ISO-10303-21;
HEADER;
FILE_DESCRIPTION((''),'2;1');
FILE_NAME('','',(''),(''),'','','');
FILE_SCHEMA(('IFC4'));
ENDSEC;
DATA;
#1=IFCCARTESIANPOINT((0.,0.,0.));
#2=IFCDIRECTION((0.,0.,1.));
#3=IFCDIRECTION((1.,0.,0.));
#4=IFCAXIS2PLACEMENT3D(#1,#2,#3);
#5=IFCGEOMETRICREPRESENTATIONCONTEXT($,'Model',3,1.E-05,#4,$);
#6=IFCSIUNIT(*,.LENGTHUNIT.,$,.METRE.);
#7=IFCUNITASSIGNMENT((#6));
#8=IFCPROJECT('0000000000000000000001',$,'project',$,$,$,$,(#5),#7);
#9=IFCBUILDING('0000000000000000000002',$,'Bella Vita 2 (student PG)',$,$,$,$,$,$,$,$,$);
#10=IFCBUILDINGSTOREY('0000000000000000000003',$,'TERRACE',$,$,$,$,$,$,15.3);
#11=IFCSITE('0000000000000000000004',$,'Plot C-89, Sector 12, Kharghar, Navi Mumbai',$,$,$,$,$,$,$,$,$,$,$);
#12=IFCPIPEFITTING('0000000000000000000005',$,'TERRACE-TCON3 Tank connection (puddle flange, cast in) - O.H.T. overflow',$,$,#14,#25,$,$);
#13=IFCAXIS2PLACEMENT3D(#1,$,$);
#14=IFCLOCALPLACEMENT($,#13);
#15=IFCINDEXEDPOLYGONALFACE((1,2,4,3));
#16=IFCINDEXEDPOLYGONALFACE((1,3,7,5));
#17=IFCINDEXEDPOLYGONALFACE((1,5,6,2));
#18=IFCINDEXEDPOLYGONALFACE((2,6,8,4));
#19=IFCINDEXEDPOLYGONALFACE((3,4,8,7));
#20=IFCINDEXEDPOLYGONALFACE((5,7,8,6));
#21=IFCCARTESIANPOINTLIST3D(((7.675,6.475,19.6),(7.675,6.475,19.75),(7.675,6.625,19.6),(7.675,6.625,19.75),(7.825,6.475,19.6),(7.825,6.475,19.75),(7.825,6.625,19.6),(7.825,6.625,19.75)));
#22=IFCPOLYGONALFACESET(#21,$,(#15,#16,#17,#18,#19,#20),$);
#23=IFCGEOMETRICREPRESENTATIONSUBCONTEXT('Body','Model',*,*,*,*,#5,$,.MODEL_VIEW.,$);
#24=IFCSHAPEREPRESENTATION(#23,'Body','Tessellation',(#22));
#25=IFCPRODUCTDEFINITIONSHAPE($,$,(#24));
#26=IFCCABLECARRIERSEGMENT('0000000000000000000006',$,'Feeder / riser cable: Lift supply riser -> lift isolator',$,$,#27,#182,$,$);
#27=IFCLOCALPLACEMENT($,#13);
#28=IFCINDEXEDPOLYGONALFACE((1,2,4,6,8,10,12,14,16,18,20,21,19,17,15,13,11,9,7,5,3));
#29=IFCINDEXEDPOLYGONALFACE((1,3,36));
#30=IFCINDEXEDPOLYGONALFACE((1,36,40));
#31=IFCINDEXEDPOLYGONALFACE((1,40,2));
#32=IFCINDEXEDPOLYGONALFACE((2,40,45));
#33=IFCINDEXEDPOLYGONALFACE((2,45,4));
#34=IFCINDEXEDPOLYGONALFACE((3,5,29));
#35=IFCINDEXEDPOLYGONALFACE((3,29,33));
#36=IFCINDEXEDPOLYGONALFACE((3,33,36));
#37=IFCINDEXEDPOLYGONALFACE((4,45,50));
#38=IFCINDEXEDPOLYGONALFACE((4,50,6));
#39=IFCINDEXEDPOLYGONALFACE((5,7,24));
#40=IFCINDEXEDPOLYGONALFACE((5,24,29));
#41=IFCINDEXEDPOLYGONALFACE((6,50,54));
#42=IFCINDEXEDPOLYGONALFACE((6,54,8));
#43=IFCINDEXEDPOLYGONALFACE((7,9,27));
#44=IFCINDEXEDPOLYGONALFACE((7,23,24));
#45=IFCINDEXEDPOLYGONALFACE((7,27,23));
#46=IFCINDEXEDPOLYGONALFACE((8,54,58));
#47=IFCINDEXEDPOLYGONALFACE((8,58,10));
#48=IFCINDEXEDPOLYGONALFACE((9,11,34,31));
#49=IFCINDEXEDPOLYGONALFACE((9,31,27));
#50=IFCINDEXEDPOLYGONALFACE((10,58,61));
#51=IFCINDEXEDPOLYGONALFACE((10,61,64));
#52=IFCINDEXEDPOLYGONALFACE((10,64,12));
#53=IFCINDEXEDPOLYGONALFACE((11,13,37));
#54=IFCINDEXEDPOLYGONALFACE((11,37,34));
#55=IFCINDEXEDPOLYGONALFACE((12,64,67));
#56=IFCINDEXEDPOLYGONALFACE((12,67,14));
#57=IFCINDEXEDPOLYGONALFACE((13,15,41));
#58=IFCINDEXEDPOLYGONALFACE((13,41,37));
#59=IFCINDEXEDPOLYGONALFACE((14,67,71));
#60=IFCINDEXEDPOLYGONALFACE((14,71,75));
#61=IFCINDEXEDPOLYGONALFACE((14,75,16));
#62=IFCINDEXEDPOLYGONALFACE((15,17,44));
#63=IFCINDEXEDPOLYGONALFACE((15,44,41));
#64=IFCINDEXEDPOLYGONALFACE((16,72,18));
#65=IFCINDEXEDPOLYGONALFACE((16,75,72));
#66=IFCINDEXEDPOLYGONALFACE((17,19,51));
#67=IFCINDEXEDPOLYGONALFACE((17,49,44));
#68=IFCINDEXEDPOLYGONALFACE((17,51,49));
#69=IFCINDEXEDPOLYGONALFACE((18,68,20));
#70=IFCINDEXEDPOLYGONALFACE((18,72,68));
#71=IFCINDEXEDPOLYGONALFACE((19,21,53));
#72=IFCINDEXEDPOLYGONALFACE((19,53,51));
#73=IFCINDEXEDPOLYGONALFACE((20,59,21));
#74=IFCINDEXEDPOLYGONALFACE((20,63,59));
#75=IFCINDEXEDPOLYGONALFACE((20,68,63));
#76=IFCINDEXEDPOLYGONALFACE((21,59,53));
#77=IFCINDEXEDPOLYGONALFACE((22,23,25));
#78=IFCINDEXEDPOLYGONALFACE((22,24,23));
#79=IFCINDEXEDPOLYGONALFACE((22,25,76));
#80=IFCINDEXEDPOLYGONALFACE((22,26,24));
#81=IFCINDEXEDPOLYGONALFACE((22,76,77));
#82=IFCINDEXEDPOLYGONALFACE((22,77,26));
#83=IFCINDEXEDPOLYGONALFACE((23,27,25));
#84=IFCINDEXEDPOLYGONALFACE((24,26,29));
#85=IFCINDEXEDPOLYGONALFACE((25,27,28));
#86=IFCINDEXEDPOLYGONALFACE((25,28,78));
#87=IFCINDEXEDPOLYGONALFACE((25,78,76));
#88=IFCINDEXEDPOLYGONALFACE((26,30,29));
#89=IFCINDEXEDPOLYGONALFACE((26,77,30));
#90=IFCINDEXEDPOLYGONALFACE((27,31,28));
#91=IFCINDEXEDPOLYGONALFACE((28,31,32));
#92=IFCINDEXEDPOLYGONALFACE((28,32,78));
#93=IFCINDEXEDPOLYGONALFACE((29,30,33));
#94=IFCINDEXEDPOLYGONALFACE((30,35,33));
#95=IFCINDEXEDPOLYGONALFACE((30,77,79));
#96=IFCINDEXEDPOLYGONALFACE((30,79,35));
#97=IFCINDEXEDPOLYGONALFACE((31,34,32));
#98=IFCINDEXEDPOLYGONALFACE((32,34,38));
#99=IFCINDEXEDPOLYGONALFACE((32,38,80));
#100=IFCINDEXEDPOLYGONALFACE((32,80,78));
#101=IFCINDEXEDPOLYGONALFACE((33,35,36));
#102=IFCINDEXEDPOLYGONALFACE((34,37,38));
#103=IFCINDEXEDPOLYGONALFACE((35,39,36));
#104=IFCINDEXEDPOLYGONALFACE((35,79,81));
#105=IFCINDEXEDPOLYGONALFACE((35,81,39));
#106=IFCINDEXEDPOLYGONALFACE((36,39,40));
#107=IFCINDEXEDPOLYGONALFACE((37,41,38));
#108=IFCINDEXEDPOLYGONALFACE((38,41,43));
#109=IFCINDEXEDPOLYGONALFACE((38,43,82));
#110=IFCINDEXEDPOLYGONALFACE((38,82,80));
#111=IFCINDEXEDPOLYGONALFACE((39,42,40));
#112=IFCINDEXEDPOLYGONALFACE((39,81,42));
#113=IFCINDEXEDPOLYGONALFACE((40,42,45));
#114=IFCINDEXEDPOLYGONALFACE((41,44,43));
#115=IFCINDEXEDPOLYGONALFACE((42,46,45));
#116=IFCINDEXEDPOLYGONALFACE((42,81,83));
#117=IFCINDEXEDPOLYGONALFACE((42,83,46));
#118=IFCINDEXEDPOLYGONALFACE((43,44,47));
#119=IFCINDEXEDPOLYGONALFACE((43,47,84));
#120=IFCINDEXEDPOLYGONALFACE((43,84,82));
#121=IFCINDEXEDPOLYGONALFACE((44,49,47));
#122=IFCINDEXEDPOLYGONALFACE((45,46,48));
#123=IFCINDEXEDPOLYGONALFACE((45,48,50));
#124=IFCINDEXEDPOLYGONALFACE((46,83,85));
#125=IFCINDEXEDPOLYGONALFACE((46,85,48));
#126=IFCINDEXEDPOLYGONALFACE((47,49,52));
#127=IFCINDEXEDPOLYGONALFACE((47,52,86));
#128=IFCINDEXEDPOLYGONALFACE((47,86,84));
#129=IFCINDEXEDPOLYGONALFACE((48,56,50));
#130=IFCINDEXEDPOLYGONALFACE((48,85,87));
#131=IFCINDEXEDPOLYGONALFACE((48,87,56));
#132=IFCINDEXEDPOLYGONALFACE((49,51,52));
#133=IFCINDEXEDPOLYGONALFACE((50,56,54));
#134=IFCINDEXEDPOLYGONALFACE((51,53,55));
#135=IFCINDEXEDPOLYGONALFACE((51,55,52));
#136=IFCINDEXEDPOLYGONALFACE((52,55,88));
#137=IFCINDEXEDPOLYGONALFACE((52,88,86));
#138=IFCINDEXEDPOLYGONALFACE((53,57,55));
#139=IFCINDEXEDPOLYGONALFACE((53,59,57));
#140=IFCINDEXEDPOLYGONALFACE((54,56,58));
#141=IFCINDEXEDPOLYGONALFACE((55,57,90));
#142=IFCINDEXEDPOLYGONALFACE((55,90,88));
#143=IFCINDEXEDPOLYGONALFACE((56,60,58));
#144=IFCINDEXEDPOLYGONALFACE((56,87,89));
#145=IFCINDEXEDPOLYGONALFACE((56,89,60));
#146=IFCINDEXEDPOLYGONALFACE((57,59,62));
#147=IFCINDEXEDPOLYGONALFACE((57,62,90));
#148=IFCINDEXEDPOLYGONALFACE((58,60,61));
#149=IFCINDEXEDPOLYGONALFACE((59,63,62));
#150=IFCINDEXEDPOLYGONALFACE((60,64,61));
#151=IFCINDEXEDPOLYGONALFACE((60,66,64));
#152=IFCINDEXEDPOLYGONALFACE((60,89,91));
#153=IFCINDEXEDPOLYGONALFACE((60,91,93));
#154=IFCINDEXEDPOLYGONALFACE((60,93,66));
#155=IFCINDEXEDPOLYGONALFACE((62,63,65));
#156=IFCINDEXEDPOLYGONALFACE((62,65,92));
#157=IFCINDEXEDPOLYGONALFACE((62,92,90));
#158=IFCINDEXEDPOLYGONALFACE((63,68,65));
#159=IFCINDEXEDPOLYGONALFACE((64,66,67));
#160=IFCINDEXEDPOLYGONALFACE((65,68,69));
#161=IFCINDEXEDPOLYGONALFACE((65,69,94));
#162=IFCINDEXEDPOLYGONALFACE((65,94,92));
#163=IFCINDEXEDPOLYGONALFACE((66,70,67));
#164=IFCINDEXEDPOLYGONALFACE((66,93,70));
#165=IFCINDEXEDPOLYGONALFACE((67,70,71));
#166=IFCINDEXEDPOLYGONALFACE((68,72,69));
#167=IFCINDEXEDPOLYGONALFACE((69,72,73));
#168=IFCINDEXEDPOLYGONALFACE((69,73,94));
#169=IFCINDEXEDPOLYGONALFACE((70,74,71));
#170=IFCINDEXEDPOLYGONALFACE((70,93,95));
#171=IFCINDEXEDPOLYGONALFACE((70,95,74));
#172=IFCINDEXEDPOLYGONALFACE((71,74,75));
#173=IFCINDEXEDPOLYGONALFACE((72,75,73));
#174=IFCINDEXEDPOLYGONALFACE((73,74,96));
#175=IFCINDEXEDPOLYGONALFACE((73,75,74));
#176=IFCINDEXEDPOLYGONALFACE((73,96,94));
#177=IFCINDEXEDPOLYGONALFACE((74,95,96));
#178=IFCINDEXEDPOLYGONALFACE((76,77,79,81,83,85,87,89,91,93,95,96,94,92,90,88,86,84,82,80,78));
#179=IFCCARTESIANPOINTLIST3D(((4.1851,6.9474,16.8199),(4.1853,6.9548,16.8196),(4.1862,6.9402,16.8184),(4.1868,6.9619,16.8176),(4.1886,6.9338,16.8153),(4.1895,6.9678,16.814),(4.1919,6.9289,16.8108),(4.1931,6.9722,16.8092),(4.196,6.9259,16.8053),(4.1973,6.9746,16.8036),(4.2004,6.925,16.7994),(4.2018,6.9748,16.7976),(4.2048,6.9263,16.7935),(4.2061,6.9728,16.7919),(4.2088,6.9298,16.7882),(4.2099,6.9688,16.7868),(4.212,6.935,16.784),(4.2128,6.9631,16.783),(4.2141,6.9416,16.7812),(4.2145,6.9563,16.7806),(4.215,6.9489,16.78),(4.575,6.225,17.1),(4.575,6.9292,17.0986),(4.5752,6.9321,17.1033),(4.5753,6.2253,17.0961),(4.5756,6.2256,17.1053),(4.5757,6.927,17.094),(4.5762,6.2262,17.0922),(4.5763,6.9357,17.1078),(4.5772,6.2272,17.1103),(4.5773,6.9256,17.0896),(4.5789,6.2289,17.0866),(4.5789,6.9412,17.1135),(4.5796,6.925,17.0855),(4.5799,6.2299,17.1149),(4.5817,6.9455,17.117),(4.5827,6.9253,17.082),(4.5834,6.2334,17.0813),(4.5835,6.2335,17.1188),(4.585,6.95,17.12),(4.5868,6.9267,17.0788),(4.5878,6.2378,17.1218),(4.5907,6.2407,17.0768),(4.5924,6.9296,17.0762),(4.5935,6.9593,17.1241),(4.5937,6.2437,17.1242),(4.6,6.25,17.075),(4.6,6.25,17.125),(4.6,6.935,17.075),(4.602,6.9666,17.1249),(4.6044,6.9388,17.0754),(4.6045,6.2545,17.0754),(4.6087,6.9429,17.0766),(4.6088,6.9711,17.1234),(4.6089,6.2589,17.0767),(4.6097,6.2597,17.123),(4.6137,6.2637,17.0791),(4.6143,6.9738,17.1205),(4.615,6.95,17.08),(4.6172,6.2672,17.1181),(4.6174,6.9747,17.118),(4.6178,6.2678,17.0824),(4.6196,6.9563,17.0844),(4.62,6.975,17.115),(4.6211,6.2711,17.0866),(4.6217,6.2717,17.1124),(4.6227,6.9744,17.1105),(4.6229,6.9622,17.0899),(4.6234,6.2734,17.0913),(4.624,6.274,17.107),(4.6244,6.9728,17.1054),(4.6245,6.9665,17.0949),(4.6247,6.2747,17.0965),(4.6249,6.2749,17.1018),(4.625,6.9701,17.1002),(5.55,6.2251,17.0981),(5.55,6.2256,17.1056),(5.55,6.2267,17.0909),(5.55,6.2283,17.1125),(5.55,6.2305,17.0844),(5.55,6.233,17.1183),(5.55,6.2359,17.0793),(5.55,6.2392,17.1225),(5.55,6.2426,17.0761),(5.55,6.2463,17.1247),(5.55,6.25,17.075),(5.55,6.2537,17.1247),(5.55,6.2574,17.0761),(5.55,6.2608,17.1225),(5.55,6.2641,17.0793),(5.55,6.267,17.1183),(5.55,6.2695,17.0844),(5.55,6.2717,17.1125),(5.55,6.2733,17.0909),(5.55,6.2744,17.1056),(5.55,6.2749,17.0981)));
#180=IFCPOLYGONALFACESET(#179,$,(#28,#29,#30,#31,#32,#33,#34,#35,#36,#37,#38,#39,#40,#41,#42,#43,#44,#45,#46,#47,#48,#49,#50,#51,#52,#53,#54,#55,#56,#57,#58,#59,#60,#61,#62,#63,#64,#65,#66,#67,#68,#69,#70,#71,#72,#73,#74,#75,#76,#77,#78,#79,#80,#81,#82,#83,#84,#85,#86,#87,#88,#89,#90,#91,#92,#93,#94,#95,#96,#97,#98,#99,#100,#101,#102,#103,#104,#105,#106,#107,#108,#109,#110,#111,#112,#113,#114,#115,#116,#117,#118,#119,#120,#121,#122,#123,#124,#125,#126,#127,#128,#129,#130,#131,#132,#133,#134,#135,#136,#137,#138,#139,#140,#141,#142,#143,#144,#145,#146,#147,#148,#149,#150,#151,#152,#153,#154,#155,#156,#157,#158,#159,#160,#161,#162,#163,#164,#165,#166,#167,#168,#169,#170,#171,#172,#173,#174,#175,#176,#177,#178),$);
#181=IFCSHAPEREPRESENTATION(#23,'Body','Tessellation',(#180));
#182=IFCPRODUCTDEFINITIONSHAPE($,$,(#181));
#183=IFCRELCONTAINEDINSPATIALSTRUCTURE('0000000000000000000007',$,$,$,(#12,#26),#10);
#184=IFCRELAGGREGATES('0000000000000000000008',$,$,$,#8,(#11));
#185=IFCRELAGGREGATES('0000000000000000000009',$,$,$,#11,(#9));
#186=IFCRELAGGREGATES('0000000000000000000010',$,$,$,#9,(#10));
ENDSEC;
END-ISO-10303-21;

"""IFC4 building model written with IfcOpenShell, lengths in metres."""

from ifc_helpers import new_model, entity, si_unit, frame, origin, origin_with_axes, origin_2d, place, context, subcontext, project, spatial, rectangle, extrude, element, save


model = new_model("IFC4")

# Units and contexts
model_context = context("Model", 3, precision=1e-05, world=origin_with_axes())
body_context = subcontext(model_context, "Body", "Model", "MODEL_VIEW")
ifc_project = project(units=[si_unit("LENGTHUNIT", "METRE")], contexts=[model_context])

# Site, building, storey
site = spatial("IfcSite", under=ifc_project, Name="Plot C-89, Sector 12, Kharghar, Navi Mumbai")
building = spatial("IfcBuilding", under=site, Name="Bella Vita 2 (student PG)")
storey = spatial("IfcBuildingStorey", under=building, Name="TERRACE", Elevation=15.3)

# Pipe fitting
pipe_fitting_1_placement = place(None, origin())
element("IfcPipeFitting", 1, at=pipe_fitting_1_placement, inside=storey, Name="TERRACE-TCON3 Tank connection (puddle flange, cast in) - O.H.T. overflow", context=body_context, shape_type="SweptSolid", body=[
    extrude(rectangle(XDim=0.15, YDim=0.15, at=origin_2d()), frame((7.75, 6.55, 19.6)), (0.0, 0.0, 1.0), 0.15),
])

# Cable carrier segment
cable_carrier_segment_placement = place(None, origin())
element("IfcCableCarrierSegment", 2, at=cable_carrier_segment_placement, inside=storey, Name="Feeder / riser cable: Lift supply riser -> lift isolator", context=body_context, shape_type="AdvancedSweptSolid", body=[
    entity("IfcSweptDiskSolid", entity("IfcPolyline", [entity("IfcCartesianPoint", [5.55, 6.25, 17.1]), entity("IfcCartesianPoint", [4.6, 6.25, 17.1]), entity("IfcCartesianPoint", [4.6, 6.95, 17.1]), entity("IfcCartesianPoint", [4.2, 6.95, 16.8])]), 0.025),
])

save(model, "model.ifc")
